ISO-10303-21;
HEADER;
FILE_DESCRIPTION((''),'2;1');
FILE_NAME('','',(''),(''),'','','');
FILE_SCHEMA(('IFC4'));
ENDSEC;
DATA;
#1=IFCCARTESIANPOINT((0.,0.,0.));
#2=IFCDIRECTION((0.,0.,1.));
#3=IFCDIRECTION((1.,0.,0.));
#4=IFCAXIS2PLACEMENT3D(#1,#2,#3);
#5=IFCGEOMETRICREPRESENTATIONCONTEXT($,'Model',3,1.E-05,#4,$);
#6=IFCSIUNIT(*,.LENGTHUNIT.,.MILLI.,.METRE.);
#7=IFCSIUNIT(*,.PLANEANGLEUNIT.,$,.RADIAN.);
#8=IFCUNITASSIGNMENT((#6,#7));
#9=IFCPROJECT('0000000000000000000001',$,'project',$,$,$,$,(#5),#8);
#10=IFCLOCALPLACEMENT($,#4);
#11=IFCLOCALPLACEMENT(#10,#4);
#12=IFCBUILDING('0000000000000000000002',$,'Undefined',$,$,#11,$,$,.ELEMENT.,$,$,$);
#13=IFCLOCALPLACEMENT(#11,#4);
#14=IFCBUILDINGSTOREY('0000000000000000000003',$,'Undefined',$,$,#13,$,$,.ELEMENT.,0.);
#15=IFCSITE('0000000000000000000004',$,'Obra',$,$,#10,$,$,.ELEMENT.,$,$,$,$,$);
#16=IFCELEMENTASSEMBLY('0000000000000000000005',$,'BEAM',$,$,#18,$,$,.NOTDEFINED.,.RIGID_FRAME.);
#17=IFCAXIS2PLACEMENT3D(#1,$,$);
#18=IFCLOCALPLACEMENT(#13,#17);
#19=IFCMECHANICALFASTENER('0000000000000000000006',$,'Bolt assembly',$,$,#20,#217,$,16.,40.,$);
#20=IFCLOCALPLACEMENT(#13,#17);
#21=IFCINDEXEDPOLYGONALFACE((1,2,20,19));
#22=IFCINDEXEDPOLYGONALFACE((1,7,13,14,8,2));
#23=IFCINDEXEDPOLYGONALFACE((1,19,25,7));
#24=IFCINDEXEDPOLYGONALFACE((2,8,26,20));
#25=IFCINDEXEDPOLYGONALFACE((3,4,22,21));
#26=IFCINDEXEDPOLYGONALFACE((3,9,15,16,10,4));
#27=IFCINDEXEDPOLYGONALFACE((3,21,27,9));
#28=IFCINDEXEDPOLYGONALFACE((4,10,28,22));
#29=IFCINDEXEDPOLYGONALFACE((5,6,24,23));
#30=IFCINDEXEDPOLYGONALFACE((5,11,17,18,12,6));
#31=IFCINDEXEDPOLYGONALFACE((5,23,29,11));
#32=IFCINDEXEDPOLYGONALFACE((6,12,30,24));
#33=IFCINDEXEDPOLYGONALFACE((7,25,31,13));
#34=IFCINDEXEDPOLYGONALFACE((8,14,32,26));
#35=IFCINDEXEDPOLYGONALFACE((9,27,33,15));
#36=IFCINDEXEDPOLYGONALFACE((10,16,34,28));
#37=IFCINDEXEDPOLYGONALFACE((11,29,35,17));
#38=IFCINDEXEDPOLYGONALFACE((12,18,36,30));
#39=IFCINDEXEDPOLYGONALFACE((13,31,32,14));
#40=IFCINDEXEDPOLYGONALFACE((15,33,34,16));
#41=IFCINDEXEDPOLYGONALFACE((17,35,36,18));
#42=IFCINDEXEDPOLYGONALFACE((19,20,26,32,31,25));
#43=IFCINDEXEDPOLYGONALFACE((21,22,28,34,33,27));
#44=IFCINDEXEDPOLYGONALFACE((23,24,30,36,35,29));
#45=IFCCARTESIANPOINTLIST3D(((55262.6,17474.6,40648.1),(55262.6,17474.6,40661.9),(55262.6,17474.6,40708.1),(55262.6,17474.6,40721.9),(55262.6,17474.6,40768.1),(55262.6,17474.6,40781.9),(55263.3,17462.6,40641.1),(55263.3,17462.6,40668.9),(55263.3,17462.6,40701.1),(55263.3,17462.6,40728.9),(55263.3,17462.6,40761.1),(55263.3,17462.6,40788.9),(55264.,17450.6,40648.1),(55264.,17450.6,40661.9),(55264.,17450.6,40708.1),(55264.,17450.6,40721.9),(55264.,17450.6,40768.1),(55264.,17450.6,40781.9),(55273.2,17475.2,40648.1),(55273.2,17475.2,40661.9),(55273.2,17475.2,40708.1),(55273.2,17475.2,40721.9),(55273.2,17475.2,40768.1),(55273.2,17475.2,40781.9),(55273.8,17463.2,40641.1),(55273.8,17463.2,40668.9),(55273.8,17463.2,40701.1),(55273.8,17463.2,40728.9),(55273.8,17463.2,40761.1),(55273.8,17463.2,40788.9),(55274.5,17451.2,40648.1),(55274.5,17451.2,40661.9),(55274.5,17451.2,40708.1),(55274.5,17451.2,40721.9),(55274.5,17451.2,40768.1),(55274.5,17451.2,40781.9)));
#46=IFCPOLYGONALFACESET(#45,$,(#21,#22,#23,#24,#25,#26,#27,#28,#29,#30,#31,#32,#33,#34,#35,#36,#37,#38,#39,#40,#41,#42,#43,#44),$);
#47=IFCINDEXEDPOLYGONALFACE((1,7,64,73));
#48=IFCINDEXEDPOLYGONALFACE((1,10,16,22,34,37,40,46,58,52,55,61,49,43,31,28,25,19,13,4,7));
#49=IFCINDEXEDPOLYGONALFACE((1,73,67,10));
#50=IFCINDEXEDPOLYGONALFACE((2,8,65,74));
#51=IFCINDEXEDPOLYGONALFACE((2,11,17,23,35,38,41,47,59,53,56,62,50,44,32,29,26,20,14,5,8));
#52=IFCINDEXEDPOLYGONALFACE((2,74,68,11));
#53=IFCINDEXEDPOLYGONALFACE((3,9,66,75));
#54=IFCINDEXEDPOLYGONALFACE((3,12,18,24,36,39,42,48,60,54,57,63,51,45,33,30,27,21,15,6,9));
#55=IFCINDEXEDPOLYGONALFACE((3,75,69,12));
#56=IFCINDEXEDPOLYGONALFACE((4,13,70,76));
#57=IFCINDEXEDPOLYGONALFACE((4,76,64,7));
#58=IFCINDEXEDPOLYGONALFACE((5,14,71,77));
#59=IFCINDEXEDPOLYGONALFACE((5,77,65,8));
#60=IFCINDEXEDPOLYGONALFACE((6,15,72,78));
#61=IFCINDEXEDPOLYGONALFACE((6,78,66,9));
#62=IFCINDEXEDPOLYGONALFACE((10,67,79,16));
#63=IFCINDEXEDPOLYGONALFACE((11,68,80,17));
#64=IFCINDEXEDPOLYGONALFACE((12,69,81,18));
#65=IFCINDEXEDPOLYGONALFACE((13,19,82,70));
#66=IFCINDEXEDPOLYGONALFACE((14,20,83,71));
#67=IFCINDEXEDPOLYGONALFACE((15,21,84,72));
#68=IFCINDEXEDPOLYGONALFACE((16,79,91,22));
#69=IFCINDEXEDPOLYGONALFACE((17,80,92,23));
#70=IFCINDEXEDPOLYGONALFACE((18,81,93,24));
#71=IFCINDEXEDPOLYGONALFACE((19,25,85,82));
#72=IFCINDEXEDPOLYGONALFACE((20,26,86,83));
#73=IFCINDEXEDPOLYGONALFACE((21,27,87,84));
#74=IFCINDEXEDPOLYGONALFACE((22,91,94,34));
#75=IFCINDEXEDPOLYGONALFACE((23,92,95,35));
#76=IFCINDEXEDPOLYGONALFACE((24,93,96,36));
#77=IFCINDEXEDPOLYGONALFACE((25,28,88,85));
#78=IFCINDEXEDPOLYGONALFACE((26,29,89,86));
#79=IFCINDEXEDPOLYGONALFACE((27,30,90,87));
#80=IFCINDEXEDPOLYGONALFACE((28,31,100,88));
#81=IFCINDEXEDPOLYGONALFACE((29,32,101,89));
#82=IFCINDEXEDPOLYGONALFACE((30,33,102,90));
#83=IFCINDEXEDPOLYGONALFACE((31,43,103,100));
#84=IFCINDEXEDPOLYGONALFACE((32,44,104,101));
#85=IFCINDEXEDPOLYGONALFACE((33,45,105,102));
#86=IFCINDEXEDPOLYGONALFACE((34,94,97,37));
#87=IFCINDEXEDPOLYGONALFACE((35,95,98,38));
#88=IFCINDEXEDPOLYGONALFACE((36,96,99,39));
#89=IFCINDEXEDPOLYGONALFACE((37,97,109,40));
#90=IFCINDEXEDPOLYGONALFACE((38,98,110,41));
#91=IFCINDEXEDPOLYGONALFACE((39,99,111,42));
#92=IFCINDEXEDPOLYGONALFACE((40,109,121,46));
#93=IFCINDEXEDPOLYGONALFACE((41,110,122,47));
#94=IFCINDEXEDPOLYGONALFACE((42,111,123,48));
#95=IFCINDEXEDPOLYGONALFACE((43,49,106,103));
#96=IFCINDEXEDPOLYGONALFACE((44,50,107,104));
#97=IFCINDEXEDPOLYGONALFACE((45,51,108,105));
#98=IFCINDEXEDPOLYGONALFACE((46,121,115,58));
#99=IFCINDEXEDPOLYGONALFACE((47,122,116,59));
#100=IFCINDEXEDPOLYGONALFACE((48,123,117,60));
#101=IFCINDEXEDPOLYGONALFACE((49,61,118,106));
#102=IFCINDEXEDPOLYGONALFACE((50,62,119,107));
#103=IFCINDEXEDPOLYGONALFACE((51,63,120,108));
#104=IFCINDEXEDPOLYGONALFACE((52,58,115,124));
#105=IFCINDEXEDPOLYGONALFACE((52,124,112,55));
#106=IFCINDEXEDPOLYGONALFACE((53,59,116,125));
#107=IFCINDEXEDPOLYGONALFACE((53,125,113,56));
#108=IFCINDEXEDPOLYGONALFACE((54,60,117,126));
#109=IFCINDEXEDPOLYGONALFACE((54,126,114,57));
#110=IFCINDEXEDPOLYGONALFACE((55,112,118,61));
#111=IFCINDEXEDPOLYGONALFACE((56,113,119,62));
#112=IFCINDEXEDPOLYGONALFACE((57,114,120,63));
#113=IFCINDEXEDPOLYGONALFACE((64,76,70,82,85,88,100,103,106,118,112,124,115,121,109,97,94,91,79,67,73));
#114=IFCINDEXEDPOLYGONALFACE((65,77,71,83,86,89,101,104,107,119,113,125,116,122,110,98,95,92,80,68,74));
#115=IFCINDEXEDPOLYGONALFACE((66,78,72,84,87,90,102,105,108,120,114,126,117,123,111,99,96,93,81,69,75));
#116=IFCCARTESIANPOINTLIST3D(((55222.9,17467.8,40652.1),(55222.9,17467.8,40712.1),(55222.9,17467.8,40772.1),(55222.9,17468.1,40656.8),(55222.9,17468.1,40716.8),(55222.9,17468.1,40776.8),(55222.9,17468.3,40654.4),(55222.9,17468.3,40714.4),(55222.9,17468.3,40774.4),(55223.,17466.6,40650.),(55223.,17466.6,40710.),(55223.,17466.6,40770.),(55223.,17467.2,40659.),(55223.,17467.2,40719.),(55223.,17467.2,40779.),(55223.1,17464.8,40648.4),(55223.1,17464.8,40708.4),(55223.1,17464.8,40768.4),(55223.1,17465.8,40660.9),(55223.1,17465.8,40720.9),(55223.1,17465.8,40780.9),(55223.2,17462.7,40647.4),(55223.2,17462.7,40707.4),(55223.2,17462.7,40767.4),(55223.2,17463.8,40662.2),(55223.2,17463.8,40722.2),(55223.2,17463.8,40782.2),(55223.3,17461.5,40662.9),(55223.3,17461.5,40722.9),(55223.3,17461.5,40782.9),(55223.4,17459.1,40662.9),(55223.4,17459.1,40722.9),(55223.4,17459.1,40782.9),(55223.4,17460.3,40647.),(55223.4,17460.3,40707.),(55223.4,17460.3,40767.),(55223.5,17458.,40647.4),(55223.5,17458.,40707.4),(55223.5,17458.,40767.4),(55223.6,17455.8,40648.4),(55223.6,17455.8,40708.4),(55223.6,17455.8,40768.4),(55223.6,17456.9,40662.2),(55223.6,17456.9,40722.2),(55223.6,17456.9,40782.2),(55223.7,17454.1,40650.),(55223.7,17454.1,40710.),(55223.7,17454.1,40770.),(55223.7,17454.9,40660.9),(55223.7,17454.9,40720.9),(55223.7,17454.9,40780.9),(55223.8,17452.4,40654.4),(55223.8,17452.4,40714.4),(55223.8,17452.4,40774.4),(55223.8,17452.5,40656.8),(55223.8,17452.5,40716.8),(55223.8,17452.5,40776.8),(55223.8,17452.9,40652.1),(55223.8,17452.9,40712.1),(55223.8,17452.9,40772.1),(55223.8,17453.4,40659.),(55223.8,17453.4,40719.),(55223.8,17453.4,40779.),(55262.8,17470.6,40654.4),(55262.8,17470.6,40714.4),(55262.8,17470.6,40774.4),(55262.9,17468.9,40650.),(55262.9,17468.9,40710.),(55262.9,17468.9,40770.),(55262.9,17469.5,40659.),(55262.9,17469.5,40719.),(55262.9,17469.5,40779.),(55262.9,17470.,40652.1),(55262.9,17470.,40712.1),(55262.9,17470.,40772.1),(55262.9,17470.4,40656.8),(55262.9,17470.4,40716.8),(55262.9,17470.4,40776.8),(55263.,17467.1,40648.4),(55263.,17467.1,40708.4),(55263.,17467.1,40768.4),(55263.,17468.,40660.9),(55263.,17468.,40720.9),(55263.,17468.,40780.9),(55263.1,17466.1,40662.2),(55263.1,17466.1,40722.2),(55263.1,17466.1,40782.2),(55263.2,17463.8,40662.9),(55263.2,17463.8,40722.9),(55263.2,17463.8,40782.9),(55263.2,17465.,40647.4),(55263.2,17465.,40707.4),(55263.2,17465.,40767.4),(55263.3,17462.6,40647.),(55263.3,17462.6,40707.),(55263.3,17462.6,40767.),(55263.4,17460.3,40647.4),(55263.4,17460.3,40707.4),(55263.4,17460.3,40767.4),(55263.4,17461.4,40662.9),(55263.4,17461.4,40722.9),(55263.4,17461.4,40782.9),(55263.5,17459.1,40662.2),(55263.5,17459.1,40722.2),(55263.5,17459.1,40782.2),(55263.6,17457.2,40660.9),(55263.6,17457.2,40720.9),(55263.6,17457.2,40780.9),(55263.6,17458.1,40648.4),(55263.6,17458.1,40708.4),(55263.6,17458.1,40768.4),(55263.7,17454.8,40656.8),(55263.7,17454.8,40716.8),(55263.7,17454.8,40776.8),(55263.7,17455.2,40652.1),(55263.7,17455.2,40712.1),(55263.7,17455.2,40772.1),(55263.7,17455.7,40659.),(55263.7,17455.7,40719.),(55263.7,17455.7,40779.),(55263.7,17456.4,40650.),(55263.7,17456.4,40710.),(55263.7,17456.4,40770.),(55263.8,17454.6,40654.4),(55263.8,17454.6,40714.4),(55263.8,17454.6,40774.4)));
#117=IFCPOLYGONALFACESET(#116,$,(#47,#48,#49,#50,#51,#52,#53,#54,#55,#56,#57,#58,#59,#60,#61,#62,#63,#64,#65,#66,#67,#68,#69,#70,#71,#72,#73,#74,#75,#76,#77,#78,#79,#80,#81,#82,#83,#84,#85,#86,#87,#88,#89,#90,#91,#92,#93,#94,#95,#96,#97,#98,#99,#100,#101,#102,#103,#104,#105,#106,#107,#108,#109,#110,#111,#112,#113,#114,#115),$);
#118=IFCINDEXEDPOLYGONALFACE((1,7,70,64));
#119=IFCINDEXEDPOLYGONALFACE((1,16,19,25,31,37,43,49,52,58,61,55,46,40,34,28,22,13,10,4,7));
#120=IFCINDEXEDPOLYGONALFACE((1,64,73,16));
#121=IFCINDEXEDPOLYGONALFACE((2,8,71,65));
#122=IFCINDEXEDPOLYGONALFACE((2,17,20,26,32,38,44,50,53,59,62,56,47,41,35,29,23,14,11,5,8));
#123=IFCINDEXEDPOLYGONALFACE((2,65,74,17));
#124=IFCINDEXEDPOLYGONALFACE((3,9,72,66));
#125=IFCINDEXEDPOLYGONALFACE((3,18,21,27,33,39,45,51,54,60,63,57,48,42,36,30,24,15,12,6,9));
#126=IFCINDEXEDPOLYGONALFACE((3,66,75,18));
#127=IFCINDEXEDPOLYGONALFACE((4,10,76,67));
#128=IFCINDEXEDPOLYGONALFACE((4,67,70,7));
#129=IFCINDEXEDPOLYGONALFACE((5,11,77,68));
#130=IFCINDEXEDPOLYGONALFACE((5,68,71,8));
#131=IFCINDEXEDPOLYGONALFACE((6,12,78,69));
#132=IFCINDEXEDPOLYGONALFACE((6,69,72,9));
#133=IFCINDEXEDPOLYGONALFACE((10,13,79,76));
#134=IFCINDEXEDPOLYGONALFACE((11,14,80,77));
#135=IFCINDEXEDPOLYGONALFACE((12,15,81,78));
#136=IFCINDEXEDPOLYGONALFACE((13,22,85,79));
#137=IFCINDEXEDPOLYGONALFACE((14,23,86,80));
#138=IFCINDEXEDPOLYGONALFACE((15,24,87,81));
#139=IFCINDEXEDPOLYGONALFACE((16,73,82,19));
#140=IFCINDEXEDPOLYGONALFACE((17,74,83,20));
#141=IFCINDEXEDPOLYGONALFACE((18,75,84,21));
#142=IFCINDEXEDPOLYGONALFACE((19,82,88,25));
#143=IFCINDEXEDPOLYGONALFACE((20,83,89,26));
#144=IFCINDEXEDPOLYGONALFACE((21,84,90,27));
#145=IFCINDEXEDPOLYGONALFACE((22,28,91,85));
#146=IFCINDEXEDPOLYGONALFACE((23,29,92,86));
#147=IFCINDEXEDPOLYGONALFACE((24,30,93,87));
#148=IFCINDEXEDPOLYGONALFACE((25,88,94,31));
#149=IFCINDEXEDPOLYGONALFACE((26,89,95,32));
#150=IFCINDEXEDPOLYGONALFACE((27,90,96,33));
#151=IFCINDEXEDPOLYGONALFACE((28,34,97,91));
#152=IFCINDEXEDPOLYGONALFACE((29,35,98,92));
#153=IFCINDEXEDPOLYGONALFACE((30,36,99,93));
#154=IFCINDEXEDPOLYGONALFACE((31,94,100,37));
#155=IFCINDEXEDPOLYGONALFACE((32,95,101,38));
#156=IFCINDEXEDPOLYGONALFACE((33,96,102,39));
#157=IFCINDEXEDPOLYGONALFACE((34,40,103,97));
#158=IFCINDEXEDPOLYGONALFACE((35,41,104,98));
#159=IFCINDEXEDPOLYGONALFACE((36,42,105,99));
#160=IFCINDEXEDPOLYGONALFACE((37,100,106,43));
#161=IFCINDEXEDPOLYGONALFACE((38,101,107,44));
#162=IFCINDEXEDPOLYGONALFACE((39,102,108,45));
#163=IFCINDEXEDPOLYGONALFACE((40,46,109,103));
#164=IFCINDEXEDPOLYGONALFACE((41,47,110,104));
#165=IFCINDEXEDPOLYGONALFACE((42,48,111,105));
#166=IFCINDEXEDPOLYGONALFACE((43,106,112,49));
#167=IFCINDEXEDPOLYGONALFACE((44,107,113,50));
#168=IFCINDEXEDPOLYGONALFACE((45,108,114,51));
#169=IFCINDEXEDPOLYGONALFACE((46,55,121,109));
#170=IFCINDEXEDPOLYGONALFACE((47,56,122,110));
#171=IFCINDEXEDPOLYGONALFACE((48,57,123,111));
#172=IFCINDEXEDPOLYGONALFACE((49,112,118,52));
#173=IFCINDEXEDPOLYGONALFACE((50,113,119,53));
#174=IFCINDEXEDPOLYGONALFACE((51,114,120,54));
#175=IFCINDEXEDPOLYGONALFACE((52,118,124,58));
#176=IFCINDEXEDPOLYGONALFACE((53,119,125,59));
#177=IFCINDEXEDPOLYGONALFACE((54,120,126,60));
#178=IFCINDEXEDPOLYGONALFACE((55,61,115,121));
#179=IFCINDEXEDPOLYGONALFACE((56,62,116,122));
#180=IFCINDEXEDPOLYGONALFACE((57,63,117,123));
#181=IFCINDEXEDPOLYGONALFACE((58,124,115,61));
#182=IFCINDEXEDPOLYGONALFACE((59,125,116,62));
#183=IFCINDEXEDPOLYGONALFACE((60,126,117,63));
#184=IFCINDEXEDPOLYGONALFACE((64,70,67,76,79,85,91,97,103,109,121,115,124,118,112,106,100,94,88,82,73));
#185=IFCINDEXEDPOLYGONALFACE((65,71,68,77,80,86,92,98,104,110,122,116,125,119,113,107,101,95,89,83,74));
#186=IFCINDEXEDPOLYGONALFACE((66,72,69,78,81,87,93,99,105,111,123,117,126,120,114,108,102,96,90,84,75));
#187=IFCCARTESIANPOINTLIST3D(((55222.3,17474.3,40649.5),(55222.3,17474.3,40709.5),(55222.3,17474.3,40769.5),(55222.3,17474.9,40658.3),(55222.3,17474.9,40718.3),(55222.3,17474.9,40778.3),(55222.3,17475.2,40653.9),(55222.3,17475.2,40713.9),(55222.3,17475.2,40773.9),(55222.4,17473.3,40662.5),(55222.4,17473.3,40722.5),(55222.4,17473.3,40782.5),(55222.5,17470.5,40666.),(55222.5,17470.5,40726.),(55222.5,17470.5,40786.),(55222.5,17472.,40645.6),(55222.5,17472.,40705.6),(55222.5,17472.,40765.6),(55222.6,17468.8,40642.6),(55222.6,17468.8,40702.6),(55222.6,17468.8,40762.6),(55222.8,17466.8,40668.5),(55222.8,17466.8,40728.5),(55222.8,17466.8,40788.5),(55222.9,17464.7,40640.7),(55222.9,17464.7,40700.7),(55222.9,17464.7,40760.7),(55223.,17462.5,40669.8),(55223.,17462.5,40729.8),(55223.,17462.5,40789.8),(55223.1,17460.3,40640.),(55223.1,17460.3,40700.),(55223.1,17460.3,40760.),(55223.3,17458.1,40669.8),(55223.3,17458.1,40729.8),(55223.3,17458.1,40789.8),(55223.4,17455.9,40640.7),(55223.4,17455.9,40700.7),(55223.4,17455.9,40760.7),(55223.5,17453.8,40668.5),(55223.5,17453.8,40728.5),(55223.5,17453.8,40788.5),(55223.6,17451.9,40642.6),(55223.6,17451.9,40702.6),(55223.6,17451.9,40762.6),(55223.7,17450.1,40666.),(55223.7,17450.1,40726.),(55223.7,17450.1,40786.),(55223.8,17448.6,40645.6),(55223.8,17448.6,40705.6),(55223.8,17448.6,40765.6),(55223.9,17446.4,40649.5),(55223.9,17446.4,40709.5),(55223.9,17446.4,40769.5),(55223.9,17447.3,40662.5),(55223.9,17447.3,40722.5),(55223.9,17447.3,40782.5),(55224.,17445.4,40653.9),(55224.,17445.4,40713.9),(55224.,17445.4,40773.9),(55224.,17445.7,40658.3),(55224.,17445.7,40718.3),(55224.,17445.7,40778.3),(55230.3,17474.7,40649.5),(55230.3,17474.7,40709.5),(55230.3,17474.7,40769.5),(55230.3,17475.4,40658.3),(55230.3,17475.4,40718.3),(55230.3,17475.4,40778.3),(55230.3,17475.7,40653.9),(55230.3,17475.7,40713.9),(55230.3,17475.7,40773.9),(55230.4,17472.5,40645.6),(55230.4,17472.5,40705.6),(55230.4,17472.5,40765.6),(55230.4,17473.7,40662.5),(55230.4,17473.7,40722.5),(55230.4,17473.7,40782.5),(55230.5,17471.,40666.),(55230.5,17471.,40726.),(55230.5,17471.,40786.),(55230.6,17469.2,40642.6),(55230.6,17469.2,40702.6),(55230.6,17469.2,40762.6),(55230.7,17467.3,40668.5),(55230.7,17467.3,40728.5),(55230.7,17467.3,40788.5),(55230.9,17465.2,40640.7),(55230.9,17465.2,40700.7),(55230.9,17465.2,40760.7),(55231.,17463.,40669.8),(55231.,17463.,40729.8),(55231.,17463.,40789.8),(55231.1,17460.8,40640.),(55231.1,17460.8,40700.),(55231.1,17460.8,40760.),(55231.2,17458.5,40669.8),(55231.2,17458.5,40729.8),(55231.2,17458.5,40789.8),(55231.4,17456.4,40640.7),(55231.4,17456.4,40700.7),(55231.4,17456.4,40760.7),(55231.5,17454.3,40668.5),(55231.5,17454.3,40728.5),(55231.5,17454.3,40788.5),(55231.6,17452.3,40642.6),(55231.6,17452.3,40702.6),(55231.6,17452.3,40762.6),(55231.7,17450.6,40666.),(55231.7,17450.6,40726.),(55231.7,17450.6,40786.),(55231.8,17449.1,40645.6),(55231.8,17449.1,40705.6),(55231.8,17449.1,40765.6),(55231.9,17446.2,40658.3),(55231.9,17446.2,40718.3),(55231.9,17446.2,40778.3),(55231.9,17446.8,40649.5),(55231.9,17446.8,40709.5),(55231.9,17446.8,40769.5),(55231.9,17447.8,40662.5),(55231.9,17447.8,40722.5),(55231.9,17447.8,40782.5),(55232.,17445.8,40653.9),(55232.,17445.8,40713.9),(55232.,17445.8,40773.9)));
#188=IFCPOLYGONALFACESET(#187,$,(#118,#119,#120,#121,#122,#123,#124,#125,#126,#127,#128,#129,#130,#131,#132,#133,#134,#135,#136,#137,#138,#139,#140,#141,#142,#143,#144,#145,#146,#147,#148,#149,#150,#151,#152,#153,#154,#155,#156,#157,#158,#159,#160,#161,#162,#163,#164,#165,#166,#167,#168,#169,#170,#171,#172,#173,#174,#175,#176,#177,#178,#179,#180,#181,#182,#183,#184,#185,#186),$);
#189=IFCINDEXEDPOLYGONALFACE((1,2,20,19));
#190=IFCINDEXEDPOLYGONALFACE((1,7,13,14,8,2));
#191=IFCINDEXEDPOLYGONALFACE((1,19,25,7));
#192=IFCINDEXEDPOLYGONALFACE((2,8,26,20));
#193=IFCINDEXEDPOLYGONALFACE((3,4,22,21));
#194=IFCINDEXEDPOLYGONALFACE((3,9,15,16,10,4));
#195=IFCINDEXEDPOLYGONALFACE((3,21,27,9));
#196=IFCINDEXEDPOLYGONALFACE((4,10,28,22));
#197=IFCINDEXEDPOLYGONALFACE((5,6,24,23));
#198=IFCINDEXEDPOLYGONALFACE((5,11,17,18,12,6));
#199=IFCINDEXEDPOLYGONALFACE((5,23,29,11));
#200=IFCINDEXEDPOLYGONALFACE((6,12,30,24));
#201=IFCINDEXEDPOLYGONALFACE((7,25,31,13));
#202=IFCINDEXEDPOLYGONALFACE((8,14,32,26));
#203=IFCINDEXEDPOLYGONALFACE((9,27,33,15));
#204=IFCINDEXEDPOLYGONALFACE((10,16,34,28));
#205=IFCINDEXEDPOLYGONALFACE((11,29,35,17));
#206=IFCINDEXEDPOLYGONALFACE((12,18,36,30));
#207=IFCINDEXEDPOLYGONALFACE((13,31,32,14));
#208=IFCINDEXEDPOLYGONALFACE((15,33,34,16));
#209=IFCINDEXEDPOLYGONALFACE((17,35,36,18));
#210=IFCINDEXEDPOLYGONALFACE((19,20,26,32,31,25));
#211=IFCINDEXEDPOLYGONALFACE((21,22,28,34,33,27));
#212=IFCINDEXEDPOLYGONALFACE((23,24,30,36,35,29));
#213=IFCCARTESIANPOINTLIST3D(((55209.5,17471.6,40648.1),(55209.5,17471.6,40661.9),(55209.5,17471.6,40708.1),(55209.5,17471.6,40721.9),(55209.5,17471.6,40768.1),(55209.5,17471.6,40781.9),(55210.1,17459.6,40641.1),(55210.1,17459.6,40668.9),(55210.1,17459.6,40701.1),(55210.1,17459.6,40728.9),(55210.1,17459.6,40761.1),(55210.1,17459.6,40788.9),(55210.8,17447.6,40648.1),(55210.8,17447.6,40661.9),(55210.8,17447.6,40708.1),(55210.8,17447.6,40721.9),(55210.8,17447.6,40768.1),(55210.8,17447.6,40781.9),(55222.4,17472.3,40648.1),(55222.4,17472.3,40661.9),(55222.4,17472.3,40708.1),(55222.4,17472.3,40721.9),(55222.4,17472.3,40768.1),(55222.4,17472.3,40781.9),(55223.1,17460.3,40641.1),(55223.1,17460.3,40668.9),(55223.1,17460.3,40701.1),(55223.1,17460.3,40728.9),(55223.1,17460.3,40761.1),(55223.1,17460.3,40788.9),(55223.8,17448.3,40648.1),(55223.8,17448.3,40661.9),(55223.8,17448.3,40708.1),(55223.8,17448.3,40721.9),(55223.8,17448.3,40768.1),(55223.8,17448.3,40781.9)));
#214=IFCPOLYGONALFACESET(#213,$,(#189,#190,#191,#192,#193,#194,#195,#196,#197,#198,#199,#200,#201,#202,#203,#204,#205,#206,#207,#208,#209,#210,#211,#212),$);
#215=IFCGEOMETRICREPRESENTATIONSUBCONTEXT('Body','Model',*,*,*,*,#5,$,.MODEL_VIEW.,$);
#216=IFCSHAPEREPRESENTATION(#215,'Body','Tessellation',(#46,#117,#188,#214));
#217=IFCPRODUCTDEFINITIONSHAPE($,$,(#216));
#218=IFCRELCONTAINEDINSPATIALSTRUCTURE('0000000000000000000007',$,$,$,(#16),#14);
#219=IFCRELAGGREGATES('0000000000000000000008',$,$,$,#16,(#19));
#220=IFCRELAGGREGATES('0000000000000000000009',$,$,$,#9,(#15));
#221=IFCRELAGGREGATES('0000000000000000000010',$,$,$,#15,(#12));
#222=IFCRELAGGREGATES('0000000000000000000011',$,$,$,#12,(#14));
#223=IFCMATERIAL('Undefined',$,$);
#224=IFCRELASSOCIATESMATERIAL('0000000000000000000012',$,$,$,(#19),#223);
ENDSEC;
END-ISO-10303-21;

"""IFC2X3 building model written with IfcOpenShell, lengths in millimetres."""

from ifc_helpers import new_model, si_unit, frame, origin_with_axes, origin_2d_with_axis, place, context, subcontext, project, spatial, polyline, circle, outline, extrude, source, transform, mapped, material, element, aggregate, save


model = new_model("IFC2X3")

# Units and contexts
model_context = context("Model", 3, precision=1e-05, world=origin_with_axes())
body_context = subcontext(model_context, "Body", "Model", "MODEL_VIEW")
ifc_project = project(units=[si_unit("LENGTHUNIT", "METRE", prefix="MILLI"), si_unit("PLANEANGLEUNIT", "RADIAN")], contexts=[model_context])

# Site, building, storey
site_placement = place(None, origin_with_axes())
site = spatial("IfcSite", under=ifc_project, at=site_placement, Name="Obra", CompositionType="ELEMENT")
building_placement = place(site_placement, origin_with_axes())
building = spatial("IfcBuilding", under=site, at=building_placement, Name="Undefined", CompositionType="ELEMENT")
storey_placement = place(building_placement, origin_with_axes())
storey = spatial("IfcBuildingStorey", under=building, at=storey_placement, Name="Undefined", CompositionType="ELEMENT", Elevation=0.0)

# Element assembly
assembly_1_placement = place(storey_placement, origin_with_axes())
assembly_1 = element("IfcElementAssembly", 1, at=assembly_1_placement, inside=storey, Name="BEAM", AssemblyPlace="NOTDEFINED", PredefinedType="RIGID_FRAME")

# Mechanical fastener
ifc_material_1 = material(Name="Undefined")
shared_shape_1 = source(origin_with_axes(), body_context, "Body", "SweptSolid", [
    extrude(outline(polyline([(13.9, 0.0), (6.9, 12.0), (-6.9, 12.0), (-13.9, 0.0), (-6.9, -12.0), (6.9, -12.0), (13.9, 0.0)])), frame((0.0, -45.9, 0.0), z_axis=(0.0, 1.0, 0.0), x_axis=(1.0, 0.0, 0.0)), (0.0, 0.0, 1.0), 10.6),
    extrude(circle(Radius=8.0, at=origin_2d_with_axis()), frame((0.0, -35.3, 0.0), z_axis=(0.0, 1.0, 0.0), x_axis=(1.0, 0.0, 0.0)), (0.0, 0.0, 1.0), 40.0),
    extrude(circle(Radius=15.0, at=origin_2d_with_axis()), frame((0.0, -3.1, 0.0), z_axis=(0.0, 1.0, 0.0), x_axis=(1.0, 0.0, 0.0)), (0.0, 0.0, 1.0), 8.0),
    extrude(outline(polyline([(13.9, 0.0), (6.9, 12.0), (-6.9, 12.0), (-13.9, 0.0), (-6.9, -12.0), (6.9, -12.0), (13.9, 0.0)])), frame((0.0, 4.9, 0.0), z_axis=(0.0, 1.0, 0.0), x_axis=(1.0, 0.0, 0.0)), (0.0, 0.0, 1.0), 13.0),
])
mechanical_fastener_1_placement = place(assembly_1_placement, frame((55230.9, 17410.7, 40835.0), z_axis=(-0.057107, 0.998368, 0.0), x_axis=(0.0, 0.0, -1.0)))
mechanical_fastener_1 = element("IfcMechanicalFastener", 2, at=mechanical_fastener_1_placement, material=ifc_material_1, Name="Bolt assembly", NominalDiameter=16.0, NominalLength=40.0, context=body_context, shape_type="MappedRepresentation", body=[
    mapped(shared_shape_1, transform((60.0, 0.0, 50.0))),
    mapped(shared_shape_1, transform((120.0, 0.0, 50.0))),
    mapped(shared_shape_1, transform((180.0, 0.0, 50.0))),
])
aggregate(assembly_1, [mechanical_fastener_1])

save(model, "model.ifc")
